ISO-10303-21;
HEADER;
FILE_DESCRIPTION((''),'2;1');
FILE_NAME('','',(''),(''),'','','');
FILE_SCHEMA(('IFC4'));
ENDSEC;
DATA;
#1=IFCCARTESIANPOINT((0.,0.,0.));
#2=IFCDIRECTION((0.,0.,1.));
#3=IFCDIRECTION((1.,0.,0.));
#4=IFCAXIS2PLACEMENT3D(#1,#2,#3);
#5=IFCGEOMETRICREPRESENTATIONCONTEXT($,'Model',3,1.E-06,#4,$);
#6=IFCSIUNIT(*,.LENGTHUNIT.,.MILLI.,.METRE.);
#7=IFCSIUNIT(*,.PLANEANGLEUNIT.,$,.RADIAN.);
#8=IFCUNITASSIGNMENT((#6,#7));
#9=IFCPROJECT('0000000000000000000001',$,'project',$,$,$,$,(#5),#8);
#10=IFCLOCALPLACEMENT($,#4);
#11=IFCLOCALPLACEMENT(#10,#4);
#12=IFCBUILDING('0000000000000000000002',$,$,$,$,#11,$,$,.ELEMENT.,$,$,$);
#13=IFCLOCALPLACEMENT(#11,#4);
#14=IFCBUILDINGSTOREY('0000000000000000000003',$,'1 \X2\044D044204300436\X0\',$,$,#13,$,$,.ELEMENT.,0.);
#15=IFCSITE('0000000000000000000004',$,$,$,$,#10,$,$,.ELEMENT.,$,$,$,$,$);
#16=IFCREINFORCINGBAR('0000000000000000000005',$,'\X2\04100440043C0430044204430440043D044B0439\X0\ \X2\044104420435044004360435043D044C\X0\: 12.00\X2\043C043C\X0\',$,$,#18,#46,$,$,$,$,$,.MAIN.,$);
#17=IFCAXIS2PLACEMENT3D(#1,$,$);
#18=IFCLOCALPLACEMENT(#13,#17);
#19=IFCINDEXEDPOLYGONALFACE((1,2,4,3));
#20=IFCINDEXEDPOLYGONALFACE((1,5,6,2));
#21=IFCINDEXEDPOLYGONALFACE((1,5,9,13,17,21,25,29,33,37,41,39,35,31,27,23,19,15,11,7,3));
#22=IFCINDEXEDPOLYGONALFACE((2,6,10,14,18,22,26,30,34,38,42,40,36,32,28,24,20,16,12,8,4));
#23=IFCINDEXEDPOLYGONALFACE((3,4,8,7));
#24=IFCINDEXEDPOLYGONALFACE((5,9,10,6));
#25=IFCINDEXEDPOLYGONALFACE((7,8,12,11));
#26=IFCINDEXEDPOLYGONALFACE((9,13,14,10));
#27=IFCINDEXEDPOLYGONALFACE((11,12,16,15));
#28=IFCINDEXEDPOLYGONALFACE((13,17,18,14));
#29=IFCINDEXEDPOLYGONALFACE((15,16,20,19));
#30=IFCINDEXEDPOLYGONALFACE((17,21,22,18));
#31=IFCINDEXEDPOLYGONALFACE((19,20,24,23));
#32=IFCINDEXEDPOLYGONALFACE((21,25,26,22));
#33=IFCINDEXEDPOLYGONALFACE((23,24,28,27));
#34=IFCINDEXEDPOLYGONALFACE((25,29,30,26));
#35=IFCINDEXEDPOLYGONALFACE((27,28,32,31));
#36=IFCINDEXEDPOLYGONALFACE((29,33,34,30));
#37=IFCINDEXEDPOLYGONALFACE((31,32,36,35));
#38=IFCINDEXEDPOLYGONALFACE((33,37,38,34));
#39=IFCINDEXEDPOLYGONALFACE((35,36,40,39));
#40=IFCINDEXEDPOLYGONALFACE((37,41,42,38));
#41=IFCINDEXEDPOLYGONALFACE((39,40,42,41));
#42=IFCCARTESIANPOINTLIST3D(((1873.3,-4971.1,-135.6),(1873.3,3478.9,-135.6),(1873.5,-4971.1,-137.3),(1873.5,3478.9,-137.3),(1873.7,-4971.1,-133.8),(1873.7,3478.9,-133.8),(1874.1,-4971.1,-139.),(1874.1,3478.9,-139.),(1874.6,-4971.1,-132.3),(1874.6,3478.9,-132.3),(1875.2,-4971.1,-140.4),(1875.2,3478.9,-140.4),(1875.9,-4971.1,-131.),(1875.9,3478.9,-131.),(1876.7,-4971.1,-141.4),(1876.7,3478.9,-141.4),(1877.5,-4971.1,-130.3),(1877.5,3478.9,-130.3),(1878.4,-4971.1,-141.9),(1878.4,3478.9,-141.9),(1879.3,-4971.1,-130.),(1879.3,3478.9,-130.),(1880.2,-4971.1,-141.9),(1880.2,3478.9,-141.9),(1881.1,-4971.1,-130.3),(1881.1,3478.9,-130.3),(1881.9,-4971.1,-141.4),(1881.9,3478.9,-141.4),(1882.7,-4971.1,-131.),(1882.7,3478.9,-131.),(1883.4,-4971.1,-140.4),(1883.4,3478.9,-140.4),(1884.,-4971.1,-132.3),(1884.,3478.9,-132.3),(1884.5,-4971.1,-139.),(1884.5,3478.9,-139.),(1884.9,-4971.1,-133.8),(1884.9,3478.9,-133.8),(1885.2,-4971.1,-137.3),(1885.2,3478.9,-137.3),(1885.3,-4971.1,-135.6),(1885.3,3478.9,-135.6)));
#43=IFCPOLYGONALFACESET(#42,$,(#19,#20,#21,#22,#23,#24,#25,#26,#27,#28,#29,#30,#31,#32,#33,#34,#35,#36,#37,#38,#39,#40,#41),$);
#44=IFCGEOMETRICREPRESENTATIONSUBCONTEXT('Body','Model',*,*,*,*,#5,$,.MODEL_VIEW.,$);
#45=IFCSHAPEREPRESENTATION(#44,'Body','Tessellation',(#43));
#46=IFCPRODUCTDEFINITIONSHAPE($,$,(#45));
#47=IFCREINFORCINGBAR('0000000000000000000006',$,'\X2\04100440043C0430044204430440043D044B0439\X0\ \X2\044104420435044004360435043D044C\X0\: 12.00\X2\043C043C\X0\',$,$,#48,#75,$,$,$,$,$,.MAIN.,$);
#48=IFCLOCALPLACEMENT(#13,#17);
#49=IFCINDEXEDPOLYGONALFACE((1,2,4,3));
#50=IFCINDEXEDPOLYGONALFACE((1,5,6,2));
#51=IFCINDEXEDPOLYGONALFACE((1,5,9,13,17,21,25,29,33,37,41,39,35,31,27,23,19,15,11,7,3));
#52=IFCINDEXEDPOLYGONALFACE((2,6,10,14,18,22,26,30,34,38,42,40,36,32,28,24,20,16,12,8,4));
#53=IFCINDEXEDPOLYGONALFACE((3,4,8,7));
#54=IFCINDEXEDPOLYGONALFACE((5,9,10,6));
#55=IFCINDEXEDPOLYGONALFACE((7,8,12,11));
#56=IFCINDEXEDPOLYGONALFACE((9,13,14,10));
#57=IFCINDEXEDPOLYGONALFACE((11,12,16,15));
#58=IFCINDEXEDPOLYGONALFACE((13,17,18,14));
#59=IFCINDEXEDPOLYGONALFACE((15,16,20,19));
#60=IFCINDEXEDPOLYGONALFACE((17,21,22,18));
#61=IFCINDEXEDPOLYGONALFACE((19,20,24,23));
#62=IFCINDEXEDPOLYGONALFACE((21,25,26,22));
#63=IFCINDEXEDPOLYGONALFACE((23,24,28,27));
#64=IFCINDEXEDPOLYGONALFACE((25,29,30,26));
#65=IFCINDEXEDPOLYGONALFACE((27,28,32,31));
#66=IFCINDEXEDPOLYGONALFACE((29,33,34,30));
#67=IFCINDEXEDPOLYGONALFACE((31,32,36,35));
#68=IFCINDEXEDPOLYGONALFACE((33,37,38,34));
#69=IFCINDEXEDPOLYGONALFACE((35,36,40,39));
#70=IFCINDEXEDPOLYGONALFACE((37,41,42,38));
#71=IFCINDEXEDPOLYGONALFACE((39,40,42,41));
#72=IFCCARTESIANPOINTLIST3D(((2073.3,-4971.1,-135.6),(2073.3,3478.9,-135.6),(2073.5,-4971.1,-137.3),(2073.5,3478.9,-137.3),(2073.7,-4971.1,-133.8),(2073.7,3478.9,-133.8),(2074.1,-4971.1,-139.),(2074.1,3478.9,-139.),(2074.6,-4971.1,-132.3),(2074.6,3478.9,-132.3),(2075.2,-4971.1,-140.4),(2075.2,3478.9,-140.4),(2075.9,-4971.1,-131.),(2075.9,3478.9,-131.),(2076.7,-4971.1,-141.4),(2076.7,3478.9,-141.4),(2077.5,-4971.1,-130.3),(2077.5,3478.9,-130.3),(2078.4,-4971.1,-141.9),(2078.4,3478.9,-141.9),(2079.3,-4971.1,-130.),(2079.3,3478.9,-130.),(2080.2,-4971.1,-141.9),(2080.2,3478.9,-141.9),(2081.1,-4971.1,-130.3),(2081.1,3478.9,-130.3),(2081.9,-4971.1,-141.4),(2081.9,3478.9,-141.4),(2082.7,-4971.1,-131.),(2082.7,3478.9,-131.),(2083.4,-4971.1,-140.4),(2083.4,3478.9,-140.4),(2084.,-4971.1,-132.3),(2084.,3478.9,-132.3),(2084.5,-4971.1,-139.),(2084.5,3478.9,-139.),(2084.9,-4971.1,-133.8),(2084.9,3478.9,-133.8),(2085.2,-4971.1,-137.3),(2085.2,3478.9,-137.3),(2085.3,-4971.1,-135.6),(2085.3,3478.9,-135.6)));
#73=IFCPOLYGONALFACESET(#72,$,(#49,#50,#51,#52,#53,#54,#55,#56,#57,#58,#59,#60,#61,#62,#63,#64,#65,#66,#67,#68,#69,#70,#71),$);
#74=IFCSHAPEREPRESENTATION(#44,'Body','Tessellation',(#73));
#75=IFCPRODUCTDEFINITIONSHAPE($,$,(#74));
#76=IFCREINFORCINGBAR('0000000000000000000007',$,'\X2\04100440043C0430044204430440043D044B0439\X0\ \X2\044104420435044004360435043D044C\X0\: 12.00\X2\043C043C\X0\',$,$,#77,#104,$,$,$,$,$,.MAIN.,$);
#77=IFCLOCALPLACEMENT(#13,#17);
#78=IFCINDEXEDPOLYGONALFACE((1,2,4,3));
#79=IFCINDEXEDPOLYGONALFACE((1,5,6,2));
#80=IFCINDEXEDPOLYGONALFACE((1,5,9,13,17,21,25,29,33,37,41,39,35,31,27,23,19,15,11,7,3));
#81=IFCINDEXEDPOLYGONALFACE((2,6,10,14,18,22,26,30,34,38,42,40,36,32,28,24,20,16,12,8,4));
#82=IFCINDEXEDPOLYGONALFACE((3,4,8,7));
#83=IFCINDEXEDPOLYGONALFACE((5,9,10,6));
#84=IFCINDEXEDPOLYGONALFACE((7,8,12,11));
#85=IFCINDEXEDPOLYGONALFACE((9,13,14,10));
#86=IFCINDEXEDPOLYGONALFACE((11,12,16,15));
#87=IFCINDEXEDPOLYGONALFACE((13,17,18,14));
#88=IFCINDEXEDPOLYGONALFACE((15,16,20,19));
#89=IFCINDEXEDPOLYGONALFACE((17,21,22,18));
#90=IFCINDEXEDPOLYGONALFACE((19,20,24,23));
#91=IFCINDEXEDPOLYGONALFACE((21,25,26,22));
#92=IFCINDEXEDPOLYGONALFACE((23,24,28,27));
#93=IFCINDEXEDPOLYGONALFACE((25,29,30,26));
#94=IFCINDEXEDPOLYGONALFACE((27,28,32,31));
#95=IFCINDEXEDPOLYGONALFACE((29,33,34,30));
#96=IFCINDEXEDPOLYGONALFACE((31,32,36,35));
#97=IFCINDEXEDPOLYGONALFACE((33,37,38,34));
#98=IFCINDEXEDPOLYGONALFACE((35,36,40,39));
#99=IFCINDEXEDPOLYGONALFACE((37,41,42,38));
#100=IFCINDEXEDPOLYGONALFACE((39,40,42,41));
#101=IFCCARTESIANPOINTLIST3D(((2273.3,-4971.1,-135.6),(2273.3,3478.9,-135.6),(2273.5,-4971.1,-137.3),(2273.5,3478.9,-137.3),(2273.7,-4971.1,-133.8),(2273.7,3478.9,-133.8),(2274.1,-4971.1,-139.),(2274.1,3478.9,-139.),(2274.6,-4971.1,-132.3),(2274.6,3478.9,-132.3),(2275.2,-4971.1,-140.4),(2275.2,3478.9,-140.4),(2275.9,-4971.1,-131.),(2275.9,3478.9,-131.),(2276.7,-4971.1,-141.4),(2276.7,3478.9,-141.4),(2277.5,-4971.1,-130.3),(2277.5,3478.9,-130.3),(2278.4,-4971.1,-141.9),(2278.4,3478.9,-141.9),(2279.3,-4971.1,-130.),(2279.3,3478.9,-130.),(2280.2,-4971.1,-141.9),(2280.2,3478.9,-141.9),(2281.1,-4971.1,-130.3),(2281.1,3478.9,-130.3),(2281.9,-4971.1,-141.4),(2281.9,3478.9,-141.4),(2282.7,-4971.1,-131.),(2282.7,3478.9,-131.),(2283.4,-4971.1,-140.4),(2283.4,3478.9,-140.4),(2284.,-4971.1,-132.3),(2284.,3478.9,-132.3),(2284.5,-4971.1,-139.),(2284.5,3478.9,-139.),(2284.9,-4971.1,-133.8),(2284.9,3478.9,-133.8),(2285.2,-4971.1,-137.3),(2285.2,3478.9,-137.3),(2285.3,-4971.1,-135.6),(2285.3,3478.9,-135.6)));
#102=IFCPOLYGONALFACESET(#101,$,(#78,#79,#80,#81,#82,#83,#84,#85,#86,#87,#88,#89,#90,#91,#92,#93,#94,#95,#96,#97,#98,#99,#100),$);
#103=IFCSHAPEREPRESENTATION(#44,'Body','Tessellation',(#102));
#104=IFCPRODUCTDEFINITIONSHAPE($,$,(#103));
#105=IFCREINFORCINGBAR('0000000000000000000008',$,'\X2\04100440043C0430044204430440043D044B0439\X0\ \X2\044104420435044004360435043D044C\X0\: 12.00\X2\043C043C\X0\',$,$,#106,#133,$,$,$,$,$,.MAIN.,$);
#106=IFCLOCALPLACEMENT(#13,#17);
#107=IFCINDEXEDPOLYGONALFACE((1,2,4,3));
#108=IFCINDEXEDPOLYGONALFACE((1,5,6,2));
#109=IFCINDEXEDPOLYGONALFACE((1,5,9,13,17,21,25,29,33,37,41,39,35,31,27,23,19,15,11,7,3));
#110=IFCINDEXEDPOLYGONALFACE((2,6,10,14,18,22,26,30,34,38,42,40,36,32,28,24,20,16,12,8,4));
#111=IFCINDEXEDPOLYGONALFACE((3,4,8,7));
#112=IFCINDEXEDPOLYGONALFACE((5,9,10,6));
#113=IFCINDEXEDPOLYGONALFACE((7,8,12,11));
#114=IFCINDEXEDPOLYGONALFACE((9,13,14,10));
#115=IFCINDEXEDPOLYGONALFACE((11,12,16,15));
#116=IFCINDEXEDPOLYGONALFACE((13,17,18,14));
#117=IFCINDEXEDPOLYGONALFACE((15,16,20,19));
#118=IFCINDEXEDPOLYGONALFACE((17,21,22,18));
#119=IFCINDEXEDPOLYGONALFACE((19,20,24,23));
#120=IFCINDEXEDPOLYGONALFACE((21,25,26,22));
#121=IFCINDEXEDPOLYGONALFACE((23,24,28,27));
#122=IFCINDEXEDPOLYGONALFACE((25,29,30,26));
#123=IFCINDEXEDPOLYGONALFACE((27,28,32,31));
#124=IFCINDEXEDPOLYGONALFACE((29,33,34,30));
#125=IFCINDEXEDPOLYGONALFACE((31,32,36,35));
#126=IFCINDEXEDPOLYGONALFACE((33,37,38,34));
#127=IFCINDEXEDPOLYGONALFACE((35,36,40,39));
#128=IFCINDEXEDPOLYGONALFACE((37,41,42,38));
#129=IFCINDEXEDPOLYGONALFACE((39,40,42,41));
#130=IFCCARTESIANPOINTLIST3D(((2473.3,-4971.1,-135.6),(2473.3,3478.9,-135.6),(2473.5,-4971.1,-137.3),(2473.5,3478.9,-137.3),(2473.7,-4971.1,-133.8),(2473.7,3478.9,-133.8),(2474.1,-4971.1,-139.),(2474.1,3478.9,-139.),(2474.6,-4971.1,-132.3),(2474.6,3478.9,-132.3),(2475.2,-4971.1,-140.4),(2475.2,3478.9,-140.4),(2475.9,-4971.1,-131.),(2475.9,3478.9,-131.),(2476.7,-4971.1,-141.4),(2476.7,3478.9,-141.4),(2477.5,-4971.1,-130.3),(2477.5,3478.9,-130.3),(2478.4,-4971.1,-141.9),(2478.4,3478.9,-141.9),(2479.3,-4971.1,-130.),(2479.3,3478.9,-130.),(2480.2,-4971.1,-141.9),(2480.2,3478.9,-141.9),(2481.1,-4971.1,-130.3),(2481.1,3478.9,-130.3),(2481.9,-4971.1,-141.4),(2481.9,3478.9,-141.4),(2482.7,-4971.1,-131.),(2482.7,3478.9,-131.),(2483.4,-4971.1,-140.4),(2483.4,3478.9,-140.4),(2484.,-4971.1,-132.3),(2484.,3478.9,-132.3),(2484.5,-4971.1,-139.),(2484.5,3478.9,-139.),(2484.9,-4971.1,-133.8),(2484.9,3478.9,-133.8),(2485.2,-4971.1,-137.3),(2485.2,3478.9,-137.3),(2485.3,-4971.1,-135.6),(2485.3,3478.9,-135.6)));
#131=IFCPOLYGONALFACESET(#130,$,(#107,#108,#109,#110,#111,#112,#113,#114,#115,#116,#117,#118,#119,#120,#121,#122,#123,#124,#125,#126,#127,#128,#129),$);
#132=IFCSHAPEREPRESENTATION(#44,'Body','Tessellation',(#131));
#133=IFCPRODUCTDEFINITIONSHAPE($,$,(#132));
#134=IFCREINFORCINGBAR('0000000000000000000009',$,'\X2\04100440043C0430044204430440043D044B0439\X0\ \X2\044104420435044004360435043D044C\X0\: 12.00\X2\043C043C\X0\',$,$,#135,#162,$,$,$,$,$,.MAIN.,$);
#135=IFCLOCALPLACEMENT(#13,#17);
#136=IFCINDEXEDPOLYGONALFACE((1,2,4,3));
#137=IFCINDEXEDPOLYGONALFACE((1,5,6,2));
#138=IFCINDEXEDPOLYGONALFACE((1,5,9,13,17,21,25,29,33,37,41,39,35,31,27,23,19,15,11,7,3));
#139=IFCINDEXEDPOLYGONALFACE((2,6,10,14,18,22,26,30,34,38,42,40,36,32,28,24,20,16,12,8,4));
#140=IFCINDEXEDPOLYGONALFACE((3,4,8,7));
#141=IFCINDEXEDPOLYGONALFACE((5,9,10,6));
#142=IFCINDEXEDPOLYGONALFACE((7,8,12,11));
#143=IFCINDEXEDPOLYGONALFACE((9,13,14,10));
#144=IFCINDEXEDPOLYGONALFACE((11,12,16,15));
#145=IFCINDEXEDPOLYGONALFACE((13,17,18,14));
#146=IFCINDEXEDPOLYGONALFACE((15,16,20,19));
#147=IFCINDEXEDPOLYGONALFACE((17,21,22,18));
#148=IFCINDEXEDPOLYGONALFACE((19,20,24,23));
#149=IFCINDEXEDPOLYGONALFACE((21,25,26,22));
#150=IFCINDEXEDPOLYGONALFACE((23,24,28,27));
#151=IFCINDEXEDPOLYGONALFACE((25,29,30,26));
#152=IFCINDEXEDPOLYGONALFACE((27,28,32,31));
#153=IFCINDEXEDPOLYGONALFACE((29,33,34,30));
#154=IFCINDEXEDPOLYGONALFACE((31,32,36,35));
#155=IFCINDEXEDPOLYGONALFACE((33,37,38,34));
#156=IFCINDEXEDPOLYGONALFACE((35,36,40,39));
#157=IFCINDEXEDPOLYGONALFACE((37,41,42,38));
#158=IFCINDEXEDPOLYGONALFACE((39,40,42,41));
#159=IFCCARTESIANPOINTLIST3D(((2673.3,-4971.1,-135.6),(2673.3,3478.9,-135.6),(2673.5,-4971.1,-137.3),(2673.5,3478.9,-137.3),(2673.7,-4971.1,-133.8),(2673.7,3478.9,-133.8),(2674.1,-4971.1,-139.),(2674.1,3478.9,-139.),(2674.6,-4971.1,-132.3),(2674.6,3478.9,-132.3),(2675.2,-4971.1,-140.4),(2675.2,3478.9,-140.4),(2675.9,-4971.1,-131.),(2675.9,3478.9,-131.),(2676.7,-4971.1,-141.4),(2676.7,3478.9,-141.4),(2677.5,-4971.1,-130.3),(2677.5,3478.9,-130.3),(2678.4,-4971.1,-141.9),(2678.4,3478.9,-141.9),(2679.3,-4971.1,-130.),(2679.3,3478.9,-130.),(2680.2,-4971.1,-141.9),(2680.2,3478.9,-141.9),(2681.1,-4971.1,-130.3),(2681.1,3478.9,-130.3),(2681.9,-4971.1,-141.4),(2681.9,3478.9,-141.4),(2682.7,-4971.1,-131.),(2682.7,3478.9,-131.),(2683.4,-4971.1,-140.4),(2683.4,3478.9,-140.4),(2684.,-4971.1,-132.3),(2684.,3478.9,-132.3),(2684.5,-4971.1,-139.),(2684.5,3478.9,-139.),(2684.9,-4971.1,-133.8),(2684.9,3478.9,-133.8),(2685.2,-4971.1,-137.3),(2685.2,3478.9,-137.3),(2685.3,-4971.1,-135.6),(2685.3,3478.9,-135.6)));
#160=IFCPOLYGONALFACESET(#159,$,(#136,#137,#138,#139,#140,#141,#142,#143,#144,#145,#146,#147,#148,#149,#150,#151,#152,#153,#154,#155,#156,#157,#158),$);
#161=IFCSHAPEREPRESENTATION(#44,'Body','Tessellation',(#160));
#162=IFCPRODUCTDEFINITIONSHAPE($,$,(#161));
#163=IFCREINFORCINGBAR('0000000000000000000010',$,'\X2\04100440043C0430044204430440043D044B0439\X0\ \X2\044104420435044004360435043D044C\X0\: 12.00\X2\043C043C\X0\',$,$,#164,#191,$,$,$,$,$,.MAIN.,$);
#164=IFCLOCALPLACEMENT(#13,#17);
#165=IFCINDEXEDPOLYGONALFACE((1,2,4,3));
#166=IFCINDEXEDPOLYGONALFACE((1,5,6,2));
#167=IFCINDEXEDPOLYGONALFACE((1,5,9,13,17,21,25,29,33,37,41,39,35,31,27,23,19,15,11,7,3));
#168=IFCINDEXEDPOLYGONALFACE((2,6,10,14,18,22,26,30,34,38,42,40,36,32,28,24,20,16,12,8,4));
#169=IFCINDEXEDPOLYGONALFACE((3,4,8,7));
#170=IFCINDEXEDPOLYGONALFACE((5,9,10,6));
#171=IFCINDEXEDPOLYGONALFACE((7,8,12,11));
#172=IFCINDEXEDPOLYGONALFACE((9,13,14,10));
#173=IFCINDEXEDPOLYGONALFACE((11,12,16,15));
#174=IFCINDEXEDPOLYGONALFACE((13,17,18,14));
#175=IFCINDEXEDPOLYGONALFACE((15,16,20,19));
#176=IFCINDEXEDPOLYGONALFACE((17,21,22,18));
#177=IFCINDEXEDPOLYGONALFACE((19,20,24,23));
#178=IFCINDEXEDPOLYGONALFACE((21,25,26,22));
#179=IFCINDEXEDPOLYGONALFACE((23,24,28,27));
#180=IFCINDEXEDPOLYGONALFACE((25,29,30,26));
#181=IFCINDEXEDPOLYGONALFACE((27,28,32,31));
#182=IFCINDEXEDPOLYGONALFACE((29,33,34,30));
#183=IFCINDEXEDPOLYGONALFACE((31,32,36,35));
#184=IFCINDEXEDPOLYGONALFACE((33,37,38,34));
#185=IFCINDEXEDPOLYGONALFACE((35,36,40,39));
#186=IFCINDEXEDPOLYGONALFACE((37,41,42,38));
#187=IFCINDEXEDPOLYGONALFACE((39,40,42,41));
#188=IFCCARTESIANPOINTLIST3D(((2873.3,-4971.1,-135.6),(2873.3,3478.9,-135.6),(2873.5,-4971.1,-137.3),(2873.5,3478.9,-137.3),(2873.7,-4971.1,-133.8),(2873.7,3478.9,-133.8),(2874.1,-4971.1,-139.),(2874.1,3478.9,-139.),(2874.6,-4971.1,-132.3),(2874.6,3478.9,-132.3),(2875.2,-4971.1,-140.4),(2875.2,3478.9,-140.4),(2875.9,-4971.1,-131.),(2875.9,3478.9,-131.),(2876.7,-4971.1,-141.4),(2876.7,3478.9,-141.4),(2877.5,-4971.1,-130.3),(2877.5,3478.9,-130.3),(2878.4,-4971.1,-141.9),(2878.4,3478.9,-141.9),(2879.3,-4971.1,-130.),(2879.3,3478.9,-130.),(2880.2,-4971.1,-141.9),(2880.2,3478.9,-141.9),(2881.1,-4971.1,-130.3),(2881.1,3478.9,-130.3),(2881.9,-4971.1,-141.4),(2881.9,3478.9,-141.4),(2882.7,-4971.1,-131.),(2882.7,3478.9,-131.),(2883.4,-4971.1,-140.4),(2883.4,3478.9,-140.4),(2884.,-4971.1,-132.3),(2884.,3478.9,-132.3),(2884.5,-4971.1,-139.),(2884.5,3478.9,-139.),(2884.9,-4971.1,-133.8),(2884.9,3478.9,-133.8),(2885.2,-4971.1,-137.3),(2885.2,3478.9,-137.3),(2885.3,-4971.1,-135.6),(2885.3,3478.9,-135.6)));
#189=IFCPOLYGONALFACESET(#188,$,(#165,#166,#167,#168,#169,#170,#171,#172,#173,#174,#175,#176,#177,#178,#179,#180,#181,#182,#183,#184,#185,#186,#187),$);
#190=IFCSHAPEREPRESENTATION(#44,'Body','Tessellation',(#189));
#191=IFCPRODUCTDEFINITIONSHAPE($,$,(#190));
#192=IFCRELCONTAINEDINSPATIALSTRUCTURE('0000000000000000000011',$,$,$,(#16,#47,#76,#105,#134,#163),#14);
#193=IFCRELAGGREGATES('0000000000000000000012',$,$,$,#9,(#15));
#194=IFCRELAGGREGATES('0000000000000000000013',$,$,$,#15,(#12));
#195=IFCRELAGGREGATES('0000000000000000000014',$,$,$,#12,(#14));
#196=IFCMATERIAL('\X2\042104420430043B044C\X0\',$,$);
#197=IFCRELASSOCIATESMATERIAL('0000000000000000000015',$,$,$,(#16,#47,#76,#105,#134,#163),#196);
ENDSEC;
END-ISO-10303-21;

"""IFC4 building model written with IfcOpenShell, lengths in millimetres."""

from ifc_helpers import new_model, entity, si_unit, origin_with_axes, place, context, subcontext, project, spatial, source, transform, mapped, material, element, save


model = new_model("IFC4")

# Units and contexts
model_context = context("Model", 3, precision=1e-06, world=origin_with_axes())
body_context = subcontext(model_context, "Body", "Model", "MODEL_VIEW")
ifc_project = project(units=[si_unit("LENGTHUNIT", "METRE", prefix="MILLI"), si_unit("PLANEANGLEUNIT", "RADIAN")], contexts=[model_context])

# Site, building, storey
site_placement = place(None, origin_with_axes())
site = spatial("IfcSite", under=ifc_project, at=site_placement, CompositionType="ELEMENT")
building_placement = place(site_placement, origin_with_axes())
building = spatial("IfcBuilding", under=site, at=building_placement, CompositionType="ELEMENT")
storey_placement = place(building_placement, origin_with_axes())
storey = spatial("IfcBuildingStorey", under=building, at=storey_placement, Name="1 этаж", CompositionType="ELEMENT", Elevation=0.0)

# Reinforcing bars
ifc_material = material(Name="Сталь")
shared_shape = source(origin_with_axes(), body_context, "Body", "AdvancedSweptSolid", [
    entity("IfcSweptDiskSolid", entity("IfcIndexedPolyCurve", entity("IfcCartesianPointList3D", [[0.0, 0.0, 0.0], [8450.0, 0.0, 0.0]]), [entity("IfcLineIndex", [1, 2])]), 6.0),
])
reinforcing_bar_1_placement = place(storey_placement, origin_with_axes())
element("IfcReinforcingBar", 1, at=reinforcing_bar_1_placement, inside=storey, material=ifc_material, Name="Арматурный стержень: 12.00мм", PredefinedType="MAIN", context=body_context, shape_type="MappedRepresentation", body=[
    mapped(shared_shape, transform((1879.3, -4971.1, -136.0), x_axis=(0.0, 1.0, 0.0), y_axis=(-1.0, 0.0, 0.0), z_axis=(0.0, 0.0, 1.0), scale=1.0)),
])
reinforcing_bar_2_placement = place(storey_placement, origin_with_axes())
element("IfcReinforcingBar", 2, at=reinforcing_bar_2_placement, inside=storey, material=ifc_material, Name="Арматурный стержень: 12.00мм", PredefinedType="MAIN", context=body_context, shape_type="MappedRepresentation", body=[
    mapped(shared_shape, transform((2079.3, -4971.1, -136.0), x_axis=(0.0, 1.0, 0.0), y_axis=(-1.0, 0.0, 0.0), z_axis=(0.0, 0.0, 1.0), scale=1.0)),
])
reinforcing_bar_3_placement = place(storey_placement, origin_with_axes())
element("IfcReinforcingBar", 3, at=reinforcing_bar_3_placement, inside=storey, material=ifc_material, Name="Арматурный стержень: 12.00мм", PredefinedType="MAIN", context=body_context, shape_type="MappedRepresentation", body=[
    mapped(shared_shape, transform((2279.3, -4971.1, -136.0), x_axis=(0.0, 1.0, 0.0), y_axis=(-1.0, 0.0, 0.0), z_axis=(0.0, 0.0, 1.0), scale=1.0)),
])
reinforcing_bar_4_placement = place(storey_placement, origin_with_axes())
element("IfcReinforcingBar", 4, at=reinforcing_bar_4_placement, inside=storey, material=ifc_material, Name="Арматурный стержень: 12.00мм", PredefinedType="MAIN", context=body_context, shape_type="MappedRepresentation", body=[
    mapped(shared_shape, transform((2479.3, -4971.1, -136.0), x_axis=(0.0, 1.0, 0.0), y_axis=(-1.0, 0.0, 0.0), z_axis=(0.0, 0.0, 1.0), scale=1.0)),
])
reinforcing_bar_5_placement = place(storey_placement, origin_with_axes())
element("IfcReinforcingBar", 5, at=reinforcing_bar_5_placement, inside=storey, material=ifc_material, Name="Арматурный стержень: 12.00мм", PredefinedType="MAIN", context=body_context, shape_type="MappedRepresentation", body=[
    mapped(shared_shape, transform((2679.3, -4971.1, -136.0), x_axis=(0.0, 1.0, 0.0), y_axis=(-1.0, 0.0, 0.0), z_axis=(0.0, 0.0, 1.0), scale=1.0)),
])
reinforcing_bar_6_placement = place(storey_placement, origin_with_axes())
element("IfcReinforcingBar", 6, at=reinforcing_bar_6_placement, inside=storey, material=ifc_material, Name="Арматурный стержень: 12.00мм", PredefinedType="MAIN", context=body_context, shape_type="MappedRepresentation", body=[
    mapped(shared_shape, transform((2879.3, -4971.1, -136.0), x_axis=(0.0, 1.0, 0.0), y_axis=(-1.0, 0.0, 0.0), z_axis=(0.0, 0.0, 1.0), scale=1.0)),
])

save(model, "model.ifc")
